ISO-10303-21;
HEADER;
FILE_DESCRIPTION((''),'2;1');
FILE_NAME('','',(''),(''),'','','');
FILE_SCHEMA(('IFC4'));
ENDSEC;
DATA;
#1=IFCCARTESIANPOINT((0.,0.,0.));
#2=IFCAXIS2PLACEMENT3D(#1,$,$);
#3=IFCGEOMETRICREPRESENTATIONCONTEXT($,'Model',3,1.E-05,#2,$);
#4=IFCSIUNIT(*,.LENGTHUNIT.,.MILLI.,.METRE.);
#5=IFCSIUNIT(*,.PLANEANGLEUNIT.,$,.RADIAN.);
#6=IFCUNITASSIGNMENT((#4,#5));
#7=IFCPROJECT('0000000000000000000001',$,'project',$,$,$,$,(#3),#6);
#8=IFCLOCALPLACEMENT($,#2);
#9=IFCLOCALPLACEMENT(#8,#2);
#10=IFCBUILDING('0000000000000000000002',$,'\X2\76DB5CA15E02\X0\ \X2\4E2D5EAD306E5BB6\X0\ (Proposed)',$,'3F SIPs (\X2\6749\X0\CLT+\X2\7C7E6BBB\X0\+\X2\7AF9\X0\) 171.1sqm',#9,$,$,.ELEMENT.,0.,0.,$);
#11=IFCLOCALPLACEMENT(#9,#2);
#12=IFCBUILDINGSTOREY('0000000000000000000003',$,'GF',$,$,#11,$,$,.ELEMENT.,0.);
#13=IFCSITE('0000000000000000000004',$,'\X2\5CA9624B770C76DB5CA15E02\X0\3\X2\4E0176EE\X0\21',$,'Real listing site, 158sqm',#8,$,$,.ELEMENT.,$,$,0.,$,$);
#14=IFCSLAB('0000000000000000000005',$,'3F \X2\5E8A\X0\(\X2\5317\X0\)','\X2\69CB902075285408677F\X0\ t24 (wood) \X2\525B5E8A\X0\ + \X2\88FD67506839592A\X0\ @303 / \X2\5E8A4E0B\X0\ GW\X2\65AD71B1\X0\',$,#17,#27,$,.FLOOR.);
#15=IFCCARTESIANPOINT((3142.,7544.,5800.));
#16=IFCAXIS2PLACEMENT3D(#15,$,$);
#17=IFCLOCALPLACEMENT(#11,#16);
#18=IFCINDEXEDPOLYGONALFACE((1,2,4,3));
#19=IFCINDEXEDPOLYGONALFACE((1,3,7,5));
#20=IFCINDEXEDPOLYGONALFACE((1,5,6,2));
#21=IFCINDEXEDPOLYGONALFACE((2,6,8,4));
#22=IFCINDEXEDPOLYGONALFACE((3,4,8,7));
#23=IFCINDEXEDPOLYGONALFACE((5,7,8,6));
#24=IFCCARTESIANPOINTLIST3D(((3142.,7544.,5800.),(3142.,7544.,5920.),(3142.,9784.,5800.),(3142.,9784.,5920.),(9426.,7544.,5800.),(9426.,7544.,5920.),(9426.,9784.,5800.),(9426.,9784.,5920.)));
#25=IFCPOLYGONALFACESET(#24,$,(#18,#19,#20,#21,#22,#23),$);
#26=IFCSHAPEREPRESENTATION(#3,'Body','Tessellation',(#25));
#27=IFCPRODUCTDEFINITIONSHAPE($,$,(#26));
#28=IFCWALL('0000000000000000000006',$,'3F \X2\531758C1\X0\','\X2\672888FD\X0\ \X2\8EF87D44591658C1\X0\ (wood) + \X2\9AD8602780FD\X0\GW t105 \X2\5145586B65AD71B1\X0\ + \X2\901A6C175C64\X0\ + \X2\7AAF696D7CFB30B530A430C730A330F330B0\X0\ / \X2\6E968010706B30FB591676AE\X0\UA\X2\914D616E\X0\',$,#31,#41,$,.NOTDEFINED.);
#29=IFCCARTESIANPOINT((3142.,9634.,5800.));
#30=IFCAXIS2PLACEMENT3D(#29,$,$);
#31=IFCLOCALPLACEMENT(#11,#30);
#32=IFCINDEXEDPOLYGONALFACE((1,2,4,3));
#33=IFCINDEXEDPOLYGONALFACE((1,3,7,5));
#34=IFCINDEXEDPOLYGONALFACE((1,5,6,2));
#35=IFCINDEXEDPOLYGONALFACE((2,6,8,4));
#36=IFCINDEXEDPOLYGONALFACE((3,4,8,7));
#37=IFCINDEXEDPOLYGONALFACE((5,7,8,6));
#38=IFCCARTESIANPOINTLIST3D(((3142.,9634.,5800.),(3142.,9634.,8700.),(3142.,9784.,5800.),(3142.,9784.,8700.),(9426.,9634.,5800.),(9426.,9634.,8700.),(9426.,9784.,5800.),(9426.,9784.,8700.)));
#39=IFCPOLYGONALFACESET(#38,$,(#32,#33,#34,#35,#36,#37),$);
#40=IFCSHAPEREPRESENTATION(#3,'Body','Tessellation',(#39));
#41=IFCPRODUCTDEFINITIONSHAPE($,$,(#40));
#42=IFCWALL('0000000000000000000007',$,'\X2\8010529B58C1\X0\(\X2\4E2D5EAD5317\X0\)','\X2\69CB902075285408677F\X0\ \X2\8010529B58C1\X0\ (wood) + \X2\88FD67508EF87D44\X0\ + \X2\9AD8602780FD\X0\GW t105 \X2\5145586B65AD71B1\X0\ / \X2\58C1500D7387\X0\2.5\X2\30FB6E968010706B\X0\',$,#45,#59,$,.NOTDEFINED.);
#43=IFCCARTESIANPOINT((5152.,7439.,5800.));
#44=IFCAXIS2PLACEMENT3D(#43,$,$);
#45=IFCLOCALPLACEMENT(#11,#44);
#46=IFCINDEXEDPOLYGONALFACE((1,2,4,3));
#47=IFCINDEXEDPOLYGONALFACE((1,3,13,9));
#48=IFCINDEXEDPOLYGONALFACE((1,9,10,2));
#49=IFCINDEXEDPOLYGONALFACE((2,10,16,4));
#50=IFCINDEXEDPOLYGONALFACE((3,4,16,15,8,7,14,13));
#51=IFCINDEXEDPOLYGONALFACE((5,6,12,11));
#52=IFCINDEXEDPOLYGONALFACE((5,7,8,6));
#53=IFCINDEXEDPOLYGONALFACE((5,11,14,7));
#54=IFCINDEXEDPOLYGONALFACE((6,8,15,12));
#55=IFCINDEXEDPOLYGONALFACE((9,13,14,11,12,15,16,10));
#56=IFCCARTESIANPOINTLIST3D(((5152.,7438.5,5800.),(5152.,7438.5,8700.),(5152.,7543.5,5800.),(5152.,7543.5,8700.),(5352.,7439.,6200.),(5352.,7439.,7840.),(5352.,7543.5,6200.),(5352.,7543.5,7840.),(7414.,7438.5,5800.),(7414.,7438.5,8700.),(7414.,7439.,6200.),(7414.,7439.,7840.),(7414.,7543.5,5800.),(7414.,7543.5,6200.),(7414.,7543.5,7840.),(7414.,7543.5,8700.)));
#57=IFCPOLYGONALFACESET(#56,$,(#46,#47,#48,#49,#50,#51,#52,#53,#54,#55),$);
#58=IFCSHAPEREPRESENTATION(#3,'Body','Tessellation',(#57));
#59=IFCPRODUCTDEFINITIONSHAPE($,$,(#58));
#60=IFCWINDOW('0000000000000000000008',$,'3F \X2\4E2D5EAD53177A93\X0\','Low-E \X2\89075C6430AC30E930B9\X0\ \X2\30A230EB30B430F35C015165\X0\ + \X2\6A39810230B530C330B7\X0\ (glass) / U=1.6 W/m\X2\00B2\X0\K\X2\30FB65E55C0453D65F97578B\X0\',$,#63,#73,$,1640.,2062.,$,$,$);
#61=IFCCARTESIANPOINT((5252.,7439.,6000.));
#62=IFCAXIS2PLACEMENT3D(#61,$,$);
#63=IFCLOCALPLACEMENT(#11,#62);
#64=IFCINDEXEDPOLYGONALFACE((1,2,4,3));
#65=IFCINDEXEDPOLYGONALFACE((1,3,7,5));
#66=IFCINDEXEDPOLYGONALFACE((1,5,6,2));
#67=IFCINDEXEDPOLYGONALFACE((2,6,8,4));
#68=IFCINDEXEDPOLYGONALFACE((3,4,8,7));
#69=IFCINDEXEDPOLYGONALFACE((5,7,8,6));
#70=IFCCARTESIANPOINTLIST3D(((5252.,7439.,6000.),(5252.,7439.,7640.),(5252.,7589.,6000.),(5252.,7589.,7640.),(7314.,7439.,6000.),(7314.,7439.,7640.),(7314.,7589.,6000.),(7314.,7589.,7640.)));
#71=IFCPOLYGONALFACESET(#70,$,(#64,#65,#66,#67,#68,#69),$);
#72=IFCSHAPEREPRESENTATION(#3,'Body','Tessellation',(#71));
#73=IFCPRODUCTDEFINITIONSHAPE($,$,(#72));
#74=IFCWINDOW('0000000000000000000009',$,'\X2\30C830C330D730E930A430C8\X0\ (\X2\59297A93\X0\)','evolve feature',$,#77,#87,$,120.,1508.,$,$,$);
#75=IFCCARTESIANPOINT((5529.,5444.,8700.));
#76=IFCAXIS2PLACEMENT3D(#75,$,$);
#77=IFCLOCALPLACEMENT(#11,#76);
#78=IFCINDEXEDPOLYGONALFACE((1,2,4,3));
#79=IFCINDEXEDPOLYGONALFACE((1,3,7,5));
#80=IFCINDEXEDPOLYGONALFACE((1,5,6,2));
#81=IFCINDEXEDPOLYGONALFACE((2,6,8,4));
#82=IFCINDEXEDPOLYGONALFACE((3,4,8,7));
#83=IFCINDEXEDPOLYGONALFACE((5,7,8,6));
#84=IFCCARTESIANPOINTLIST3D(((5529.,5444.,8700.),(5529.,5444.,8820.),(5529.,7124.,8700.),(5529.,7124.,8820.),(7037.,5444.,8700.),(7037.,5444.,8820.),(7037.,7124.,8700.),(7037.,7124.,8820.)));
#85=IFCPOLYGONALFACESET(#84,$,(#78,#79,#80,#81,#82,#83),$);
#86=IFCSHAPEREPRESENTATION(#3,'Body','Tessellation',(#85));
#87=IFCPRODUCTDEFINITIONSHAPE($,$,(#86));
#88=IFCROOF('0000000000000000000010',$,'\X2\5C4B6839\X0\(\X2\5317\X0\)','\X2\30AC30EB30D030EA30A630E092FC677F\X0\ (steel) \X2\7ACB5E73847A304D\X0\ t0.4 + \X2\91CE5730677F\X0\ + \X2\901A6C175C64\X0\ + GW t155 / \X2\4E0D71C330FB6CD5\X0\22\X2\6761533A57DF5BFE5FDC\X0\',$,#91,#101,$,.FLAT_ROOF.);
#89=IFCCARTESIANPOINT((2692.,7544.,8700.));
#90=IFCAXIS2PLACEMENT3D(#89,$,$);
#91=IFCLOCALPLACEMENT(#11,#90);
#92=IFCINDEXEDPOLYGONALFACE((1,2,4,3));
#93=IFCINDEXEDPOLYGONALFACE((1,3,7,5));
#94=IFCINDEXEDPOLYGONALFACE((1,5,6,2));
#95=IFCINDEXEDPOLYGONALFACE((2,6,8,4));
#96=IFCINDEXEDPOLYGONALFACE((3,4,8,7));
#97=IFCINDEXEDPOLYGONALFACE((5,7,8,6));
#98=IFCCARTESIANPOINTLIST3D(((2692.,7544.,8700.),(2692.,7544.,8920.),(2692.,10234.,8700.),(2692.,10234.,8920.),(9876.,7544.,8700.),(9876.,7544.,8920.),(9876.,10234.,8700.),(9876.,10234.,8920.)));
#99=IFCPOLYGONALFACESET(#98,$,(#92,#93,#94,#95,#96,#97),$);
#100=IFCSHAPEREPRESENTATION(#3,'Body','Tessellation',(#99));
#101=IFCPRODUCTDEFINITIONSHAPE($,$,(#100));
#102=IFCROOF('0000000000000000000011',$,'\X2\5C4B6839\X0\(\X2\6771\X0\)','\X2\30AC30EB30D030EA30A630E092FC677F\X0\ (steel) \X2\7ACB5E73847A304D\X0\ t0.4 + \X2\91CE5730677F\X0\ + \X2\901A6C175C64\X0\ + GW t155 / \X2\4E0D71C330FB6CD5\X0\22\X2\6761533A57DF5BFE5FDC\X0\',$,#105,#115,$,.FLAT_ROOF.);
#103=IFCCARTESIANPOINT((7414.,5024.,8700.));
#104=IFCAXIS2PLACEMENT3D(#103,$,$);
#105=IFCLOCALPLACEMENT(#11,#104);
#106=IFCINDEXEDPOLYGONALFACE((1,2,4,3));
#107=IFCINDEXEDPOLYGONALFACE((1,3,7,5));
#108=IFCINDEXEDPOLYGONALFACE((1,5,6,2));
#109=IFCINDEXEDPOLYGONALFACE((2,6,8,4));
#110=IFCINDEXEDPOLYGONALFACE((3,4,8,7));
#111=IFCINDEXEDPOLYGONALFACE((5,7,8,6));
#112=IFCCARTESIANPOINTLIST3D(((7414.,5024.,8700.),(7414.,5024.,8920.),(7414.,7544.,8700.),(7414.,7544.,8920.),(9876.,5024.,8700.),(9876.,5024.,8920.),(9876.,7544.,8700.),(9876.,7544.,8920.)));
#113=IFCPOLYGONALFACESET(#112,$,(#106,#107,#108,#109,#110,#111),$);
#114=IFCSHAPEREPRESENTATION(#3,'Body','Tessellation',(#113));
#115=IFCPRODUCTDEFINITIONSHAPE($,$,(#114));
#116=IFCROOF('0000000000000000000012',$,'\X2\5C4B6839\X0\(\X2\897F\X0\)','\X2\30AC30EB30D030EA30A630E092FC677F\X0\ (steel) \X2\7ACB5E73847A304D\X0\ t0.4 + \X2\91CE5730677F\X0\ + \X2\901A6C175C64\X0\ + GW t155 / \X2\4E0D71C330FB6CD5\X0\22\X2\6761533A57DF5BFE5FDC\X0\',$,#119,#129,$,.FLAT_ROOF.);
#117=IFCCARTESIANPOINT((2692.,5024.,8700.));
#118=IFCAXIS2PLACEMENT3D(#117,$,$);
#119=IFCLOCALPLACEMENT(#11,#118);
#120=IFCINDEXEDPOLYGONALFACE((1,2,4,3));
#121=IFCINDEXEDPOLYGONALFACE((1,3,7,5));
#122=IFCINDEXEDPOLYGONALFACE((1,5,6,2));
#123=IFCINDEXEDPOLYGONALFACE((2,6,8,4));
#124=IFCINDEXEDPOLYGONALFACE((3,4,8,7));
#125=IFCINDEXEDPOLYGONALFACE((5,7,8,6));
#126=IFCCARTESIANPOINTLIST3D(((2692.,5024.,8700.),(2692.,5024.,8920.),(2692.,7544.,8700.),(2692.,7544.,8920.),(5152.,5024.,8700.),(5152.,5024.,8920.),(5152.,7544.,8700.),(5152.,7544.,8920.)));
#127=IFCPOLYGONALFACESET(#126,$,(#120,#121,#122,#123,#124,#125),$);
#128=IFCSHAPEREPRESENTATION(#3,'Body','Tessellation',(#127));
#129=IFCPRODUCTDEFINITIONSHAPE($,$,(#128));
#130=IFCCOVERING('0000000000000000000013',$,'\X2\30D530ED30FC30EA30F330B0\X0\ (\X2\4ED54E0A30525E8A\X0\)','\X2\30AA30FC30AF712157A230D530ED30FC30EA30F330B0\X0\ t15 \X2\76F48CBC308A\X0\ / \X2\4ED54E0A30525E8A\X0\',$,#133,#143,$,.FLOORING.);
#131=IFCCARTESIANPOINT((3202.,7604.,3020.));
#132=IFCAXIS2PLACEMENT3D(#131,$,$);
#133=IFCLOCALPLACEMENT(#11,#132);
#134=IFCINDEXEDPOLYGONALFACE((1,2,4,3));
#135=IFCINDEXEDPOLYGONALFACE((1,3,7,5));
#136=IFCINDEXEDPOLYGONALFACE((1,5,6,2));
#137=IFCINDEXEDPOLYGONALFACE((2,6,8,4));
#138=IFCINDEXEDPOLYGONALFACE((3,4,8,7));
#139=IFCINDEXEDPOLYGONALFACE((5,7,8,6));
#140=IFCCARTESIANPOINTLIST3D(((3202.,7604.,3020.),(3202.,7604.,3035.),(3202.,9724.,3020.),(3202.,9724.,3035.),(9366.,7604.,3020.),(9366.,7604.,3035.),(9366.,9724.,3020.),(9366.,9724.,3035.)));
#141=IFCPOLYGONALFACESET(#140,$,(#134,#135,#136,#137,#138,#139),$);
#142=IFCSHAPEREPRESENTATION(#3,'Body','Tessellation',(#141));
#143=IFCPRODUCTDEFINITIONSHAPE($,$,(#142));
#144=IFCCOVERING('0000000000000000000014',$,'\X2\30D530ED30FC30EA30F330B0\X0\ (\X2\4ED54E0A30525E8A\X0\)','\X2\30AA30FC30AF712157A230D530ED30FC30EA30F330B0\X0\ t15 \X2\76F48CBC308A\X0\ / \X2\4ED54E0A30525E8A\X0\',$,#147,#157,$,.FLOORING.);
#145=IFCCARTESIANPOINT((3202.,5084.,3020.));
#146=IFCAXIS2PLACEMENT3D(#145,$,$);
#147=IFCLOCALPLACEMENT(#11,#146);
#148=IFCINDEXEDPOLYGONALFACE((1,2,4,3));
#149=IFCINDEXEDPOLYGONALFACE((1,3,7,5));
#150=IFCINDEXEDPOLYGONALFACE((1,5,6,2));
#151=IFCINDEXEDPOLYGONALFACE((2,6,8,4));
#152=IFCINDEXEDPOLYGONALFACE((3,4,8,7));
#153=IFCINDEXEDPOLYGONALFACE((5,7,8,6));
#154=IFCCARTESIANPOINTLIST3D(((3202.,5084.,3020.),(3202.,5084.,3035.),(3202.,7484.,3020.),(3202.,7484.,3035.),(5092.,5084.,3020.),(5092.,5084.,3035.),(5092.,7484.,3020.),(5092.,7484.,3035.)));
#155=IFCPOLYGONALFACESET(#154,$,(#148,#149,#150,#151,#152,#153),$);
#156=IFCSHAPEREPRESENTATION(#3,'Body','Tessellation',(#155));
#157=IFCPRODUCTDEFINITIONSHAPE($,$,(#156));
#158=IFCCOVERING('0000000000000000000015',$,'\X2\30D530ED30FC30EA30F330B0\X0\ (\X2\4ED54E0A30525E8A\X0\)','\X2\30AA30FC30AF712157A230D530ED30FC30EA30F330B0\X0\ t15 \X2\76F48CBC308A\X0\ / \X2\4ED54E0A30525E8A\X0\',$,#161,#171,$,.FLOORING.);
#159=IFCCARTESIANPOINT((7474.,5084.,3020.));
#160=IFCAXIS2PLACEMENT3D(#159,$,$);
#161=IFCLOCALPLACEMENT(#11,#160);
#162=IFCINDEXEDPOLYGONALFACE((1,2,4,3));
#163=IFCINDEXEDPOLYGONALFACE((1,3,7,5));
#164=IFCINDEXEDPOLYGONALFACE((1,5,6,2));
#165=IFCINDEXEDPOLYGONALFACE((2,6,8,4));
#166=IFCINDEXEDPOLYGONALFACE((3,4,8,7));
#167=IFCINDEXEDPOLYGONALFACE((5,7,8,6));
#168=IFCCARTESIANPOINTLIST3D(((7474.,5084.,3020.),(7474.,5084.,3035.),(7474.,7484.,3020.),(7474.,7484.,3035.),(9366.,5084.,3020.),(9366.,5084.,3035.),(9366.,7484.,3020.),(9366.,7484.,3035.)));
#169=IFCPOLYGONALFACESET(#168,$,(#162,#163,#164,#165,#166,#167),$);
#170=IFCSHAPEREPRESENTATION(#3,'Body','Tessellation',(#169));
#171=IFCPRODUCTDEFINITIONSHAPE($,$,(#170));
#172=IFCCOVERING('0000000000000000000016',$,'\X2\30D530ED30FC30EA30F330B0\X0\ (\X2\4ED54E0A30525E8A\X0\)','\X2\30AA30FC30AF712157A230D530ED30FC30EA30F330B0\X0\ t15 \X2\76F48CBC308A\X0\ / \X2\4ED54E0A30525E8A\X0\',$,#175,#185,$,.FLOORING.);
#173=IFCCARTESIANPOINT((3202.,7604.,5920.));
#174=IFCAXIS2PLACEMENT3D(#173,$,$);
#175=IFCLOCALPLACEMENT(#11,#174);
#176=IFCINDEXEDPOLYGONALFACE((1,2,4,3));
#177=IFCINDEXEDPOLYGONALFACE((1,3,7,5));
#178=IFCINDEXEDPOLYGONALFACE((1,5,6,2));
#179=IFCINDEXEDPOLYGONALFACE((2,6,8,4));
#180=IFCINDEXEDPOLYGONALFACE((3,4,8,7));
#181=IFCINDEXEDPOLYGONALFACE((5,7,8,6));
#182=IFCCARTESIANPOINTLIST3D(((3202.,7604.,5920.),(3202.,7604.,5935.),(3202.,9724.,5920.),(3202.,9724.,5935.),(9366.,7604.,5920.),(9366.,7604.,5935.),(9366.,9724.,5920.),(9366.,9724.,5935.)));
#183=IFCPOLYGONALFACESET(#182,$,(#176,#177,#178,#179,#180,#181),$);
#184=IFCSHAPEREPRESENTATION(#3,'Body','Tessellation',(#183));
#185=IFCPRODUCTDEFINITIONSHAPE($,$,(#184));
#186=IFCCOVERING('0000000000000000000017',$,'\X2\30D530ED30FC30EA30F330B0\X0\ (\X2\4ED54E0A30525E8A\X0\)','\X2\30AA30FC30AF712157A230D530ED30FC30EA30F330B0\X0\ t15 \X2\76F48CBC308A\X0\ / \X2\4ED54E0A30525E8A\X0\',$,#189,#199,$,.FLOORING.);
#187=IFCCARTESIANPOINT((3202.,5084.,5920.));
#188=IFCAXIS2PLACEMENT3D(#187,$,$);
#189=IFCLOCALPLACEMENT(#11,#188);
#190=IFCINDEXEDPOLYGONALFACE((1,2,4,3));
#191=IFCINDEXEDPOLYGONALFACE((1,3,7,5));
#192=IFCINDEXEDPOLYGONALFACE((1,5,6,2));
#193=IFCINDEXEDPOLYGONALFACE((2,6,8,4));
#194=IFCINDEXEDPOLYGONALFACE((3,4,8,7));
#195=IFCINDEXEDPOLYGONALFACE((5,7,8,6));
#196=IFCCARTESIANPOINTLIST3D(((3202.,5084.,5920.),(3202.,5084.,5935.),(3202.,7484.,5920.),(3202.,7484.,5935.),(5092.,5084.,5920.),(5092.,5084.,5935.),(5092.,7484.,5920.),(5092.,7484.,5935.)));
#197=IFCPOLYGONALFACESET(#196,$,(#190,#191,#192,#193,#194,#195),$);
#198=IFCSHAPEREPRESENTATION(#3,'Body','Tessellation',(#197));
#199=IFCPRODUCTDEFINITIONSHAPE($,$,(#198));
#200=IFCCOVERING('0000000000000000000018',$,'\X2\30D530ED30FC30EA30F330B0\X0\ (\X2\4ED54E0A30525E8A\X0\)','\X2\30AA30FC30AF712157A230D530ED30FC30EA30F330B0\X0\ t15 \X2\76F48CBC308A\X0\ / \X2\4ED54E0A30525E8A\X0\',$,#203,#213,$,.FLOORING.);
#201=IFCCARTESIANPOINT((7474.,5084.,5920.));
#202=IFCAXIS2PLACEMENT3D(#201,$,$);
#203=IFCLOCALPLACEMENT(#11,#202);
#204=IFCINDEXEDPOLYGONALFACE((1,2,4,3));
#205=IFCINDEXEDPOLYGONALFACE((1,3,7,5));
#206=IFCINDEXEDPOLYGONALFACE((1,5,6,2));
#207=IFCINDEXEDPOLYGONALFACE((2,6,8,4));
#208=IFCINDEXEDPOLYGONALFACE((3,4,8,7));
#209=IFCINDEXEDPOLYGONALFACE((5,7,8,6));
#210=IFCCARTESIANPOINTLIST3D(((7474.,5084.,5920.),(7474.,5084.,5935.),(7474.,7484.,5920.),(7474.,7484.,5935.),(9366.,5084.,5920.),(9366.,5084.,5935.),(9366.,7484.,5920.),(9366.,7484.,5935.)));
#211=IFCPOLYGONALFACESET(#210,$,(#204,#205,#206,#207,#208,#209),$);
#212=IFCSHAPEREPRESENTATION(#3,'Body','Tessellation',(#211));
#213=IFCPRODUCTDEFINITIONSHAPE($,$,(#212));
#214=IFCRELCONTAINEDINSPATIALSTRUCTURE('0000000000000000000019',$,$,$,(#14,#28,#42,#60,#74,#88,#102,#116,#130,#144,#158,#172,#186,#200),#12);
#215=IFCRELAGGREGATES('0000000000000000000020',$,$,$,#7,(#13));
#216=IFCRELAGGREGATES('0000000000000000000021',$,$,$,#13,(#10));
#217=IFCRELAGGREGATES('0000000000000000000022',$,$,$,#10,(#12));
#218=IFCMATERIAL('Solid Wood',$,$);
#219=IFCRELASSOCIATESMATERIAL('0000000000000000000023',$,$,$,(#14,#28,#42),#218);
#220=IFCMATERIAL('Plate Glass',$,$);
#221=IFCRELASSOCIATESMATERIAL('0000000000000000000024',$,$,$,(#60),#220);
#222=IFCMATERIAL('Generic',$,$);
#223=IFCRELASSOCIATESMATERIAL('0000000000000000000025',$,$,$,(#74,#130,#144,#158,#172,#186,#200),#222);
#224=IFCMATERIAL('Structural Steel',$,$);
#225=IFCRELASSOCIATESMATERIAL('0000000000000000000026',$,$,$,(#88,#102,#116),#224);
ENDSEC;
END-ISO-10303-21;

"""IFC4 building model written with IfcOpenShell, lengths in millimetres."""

from ifc_helpers import new_model, si_unit, frame, frame_2d, origin, place, context, project, spatial, rectangle, extrude, material, element, fill, save


model = new_model("IFC4")

# Units and contexts
model_context = context("Model", 3, precision=1e-05, world=origin())
ifc_project = project(units=[si_unit("LENGTHUNIT", "METRE", prefix="MILLI"), si_unit("PLANEANGLEUNIT", "RADIAN")], contexts=[model_context])

# Site, building, storey
site_placement = place(None, origin())
site = spatial("IfcSite", under=ifc_project, at=site_placement, Name="岩手県盛岡市3丁目21", ObjectType="Real listing site, 158sqm", CompositionType="ELEMENT", RefElevation=0.0)
building_placement = place(site_placement, origin())
building = spatial("IfcBuilding", under=site, at=building_placement, Name="盛岡市 中庭の家 (Proposed)", ObjectType="3F SIPs (杉CLT+籾殻+竹) 171.1sqm", CompositionType="ELEMENT", ElevationOfRefHeight=0.0, ElevationOfTerrain=0.0)
storey_placement = place(building_placement, origin())
storey = spatial("IfcBuildingStorey", under=building, at=storey_placement, Name="GF", CompositionType="ELEMENT", Elevation=0.0)

# Slab
ifc_material_1 = material(Name="Solid Wood")
slab_placement = place(storey_placement, frame((3142.0, 7544.0, 5800.0)))
element("IfcSlab", 1, at=slab_placement, inside=storey, material=ifc_material_1, Name="3F 床(北)", Description="構造用合板 t24 (wood) 剛床 + 製材根太 @303 / 床下 GW断熱", PredefinedType="FLOOR", context=model_context, shape_type="SweptSolid", body=[
    extrude(rectangle(XDim=6284.0, YDim=2240.0, at=frame_2d((3142.0, 1120.0))), frame((3142.0, 7544.0, 5800.0)), (0.0, 0.0, 1.0), 120.0),
])

# Wall
wall_1_placement = place(storey_placement, frame((3142.0, 9634.0, 5800.0)))
element("IfcWall", 2, at=wall_1_placement, inside=storey, material=ifc_material_1, Name="3F 北壁", Description="木製 軸組外壁 (wood) + 高性能GW t105 充填断熱 + 通気層 + 窯業系サイディング / 準耐火・外皮UA配慮", PredefinedType="NOTDEFINED", context=model_context, shape_type="SweptSolid", body=[
    extrude(rectangle(XDim=6284.0, YDim=150.0, at=frame_2d((3142.0, 75.0))), frame((3142.0, 9634.0, 5800.0)), (0.0, 0.0, 1.0), 2900.0),
])

# Wall, opening, window
wall_2_placement = place(storey_placement, frame((5152.0, 7439.0, 5800.0)))
wall_2 = element("IfcWall", 3, at=wall_2_placement, inside=storey, material=ifc_material_1, Name="耐力壁(中庭北)", Description="構造用合板 耐力壁 (wood) + 製材軸組 + 高性能GW t105 充填断熱 / 壁倍率2.5・準耐火", PredefinedType="NOTDEFINED", context=model_context, shape_type="SweptSolid", body=[
    extrude(rectangle(XDim=2262.0, YDim=105.0, at=frame_2d((1131.0, 52.0))), frame((5152.0, 7439.0, 5800.0)), (0.0, 0.0, 1.0), 2900.0),
])
opening_placement = place(storey_placement, frame((5252.0, 7439.0, 6000.0)))
opening = element("IfcOpeningElement", 4, at=opening_placement, cuts=wall_2, PredefinedType="NOTDEFINED", context=model_context, shape_type="SweptSolid", body=[
    extrude(rectangle(XDim=2062.0, YDim=150.0, at=frame_2d((1031.0, 75.0))), frame((5252.0, 7439.0, 6000.0)), (0.0, 0.0, 1.0), 1640.0),
])
ifc_material_2 = material(Name="Plate Glass")
window_1_placement = place(storey_placement, frame((5252.0, 7439.0, 6000.0)))
window_1 = element("IfcWindow", 5, at=window_1_placement, inside=storey, material=ifc_material_2, Name="3F 中庭北窓", Description="Low-E 複層ガラス アルゴン封入 + 樹脂サッシ (glass) / U=1.6 W/m²K・日射取得型", OverallHeight=1640.0, OverallWidth=2062.0, context=model_context, shape_type="SweptSolid", body=[
    extrude(rectangle(XDim=2062.0, YDim=150.0, at=frame_2d((1031.0, 75.0))), frame((5252.0, 7439.0, 6000.0)), (0.0, 0.0, 1.0), 1640.0),
])
fill(opening, window_1)

# Window
ifc_material_3 = material(Name="Generic")
window_2_placement = place(storey_placement, frame((5529.0, 5444.0, 8700.0)))
element("IfcWindow", 6, at=window_2_placement, inside=storey, material=ifc_material_3, Name="トップライト (天窓)", Description="evolve feature", OverallHeight=120.0, OverallWidth=1508.0, context=model_context, shape_type="SweptSolid", body=[
    extrude(rectangle(XDim=1508.0, YDim=1680.0, at=frame_2d((754.0, 840.0))), frame((5529.0, 5444.0, 8700.0)), (0.0, 0.0, 1.0), 120.0),
])

# Roofs
ifc_material_4 = material(Name="Structural Steel")
roof_1_placement = place(storey_placement, frame((2692.0, 7544.0, 8700.0)))
element("IfcRoof", 7, at=roof_1_placement, inside=storey, material=ifc_material_4, Name="屋根(北)", Description="ガルバリウム鋼板 (steel) 立平葺き t0.4 + 野地板 + 通気層 + GW t155 / 不燃・法22条区域対応", PredefinedType="FLAT_ROOF", context=model_context, shape_type="SweptSolid", body=[
    extrude(rectangle(XDim=7184.0, YDim=2690.0, at=frame_2d((3592.0, 1345.0))), frame((2692.0, 7544.0, 8700.0)), (0.0, 0.0, 1.0), 220.0),
])
roof_2_placement = place(storey_placement, frame((7414.0, 5024.0, 8700.0)))
element("IfcRoof", 8, at=roof_2_placement, inside=storey, material=ifc_material_4, Name="屋根(東)", Description="ガルバリウム鋼板 (steel) 立平葺き t0.4 + 野地板 + 通気層 + GW t155 / 不燃・法22条区域対応", PredefinedType="FLAT_ROOF", context=model_context, shape_type="SweptSolid", body=[
    extrude(rectangle(XDim=2462.0, YDim=2520.0, at=frame_2d((1231.0, 1260.0))), frame((7414.0, 5024.0, 8700.0)), (0.0, 0.0, 1.0), 220.0),
])
roof_3_placement = place(storey_placement, frame((2692.0, 5024.0, 8700.0)))
element("IfcRoof", 9, at=roof_3_placement, inside=storey, material=ifc_material_4, Name="屋根(西)", Description="ガルバリウム鋼板 (steel) 立平葺き t0.4 + 野地板 + 通気層 + GW t155 / 不燃・法22条区域対応", PredefinedType="FLAT_ROOF", context=model_context, shape_type="SweptSolid", body=[
    extrude(rectangle(XDim=2460.0, YDim=2520.0, at=frame_2d((1230.0, 1260.0))), frame((2692.0, 5024.0, 8700.0)), (0.0, 0.0, 1.0), 220.0),
])

# Coverings
covering_1_placement = place(storey_placement, frame((3202.0, 7604.0, 3020.0)))
element("IfcCovering", 10, at=covering_1_placement, inside=storey, material=ifc_material_3, Name="フローリング (仕上げ床)", Description="オーク無垢フローリング t15 直貼り / 仕上げ床", PredefinedType="FLOORING", context=model_context, shape_type="SweptSolid", body=[
    extrude(rectangle(XDim=6164.0, YDim=2120.0, at=frame_2d((3082.0, 1060.0))), frame((3202.0, 7604.0, 3020.0)), (0.0, 0.0, 1.0), 15.0),
])
covering_2_placement = place(storey_placement, frame((3202.0, 5084.0, 3020.0)))
element("IfcCovering", 11, at=covering_2_placement, inside=storey, material=ifc_material_3, Name="フローリング (仕上げ床)", Description="オーク無垢フローリング t15 直貼り / 仕上げ床", PredefinedType="FLOORING", context=model_context, shape_type="SweptSolid", body=[
    extrude(rectangle(XDim=1890.0, YDim=2400.0, at=frame_2d((945.0, 1200.0))), frame((3202.0, 5084.0, 3020.0)), (0.0, 0.0, 1.0), 15.0),
])
covering_3_placement = place(storey_placement, frame((7474.0, 5084.0, 3020.0)))
element("IfcCovering", 12, at=covering_3_placement, inside=storey, material=ifc_material_3, Name="フローリング (仕上げ床)", Description="オーク無垢フローリング t15 直貼り / 仕上げ床", PredefinedType="FLOORING", context=model_context, shape_type="SweptSolid", body=[
    extrude(rectangle(XDim=1892.0, YDim=2400.0, at=frame_2d((946.0, 1200.0))), frame((7474.0, 5084.0, 3020.0)), (0.0, 0.0, 1.0), 15.0),
])
covering_4_placement = place(storey_placement, frame((3202.0, 7604.0, 5920.0)))
element("IfcCovering", 13, at=covering_4_placement, inside=storey, material=ifc_material_3, Name="フローリング (仕上げ床)", Description="オーク無垢フローリング t15 直貼り / 仕上げ床", PredefinedType="FLOORING", context=model_context, shape_type="SweptSolid", body=[
    extrude(rectangle(XDim=6164.0, YDim=2120.0, at=frame_2d((3082.0, 1060.0))), frame((3202.0, 7604.0, 5920.0)), (0.0, 0.0, 1.0), 15.0),
])
covering_5_placement = place(storey_placement, frame((3202.0, 5084.0, 5920.0)))
element("IfcCovering", 14, at=covering_5_placement, inside=storey, material=ifc_material_3, Name="フローリング (仕上げ床)", Description="オーク無垢フローリング t15 直貼り / 仕上げ床", PredefinedType="FLOORING", context=model_context, shape_type="SweptSolid", body=[
    extrude(rectangle(XDim=1890.0, YDim=2400.0, at=frame_2d((945.0, 1200.0))), frame((3202.0, 5084.0, 5920.0)), (0.0, 0.0, 1.0), 15.0),
])
covering_6_placement = place(storey_placement, frame((7474.0, 5084.0, 5920.0)))
element("IfcCovering", 15, at=covering_6_placement, inside=storey, material=ifc_material_3, Name="フローリング (仕上げ床)", Description="オーク無垢フローリング t15 直貼り / 仕上げ床", PredefinedType="FLOORING", context=model_context, shape_type="SweptSolid", body=[
    extrude(rectangle(XDim=1892.0, YDim=2400.0, at=frame_2d((946.0, 1200.0))), frame((7474.0, 5084.0, 5920.0)), (0.0, 0.0, 1.0), 15.0),
])

save(model, "model.ifc")
